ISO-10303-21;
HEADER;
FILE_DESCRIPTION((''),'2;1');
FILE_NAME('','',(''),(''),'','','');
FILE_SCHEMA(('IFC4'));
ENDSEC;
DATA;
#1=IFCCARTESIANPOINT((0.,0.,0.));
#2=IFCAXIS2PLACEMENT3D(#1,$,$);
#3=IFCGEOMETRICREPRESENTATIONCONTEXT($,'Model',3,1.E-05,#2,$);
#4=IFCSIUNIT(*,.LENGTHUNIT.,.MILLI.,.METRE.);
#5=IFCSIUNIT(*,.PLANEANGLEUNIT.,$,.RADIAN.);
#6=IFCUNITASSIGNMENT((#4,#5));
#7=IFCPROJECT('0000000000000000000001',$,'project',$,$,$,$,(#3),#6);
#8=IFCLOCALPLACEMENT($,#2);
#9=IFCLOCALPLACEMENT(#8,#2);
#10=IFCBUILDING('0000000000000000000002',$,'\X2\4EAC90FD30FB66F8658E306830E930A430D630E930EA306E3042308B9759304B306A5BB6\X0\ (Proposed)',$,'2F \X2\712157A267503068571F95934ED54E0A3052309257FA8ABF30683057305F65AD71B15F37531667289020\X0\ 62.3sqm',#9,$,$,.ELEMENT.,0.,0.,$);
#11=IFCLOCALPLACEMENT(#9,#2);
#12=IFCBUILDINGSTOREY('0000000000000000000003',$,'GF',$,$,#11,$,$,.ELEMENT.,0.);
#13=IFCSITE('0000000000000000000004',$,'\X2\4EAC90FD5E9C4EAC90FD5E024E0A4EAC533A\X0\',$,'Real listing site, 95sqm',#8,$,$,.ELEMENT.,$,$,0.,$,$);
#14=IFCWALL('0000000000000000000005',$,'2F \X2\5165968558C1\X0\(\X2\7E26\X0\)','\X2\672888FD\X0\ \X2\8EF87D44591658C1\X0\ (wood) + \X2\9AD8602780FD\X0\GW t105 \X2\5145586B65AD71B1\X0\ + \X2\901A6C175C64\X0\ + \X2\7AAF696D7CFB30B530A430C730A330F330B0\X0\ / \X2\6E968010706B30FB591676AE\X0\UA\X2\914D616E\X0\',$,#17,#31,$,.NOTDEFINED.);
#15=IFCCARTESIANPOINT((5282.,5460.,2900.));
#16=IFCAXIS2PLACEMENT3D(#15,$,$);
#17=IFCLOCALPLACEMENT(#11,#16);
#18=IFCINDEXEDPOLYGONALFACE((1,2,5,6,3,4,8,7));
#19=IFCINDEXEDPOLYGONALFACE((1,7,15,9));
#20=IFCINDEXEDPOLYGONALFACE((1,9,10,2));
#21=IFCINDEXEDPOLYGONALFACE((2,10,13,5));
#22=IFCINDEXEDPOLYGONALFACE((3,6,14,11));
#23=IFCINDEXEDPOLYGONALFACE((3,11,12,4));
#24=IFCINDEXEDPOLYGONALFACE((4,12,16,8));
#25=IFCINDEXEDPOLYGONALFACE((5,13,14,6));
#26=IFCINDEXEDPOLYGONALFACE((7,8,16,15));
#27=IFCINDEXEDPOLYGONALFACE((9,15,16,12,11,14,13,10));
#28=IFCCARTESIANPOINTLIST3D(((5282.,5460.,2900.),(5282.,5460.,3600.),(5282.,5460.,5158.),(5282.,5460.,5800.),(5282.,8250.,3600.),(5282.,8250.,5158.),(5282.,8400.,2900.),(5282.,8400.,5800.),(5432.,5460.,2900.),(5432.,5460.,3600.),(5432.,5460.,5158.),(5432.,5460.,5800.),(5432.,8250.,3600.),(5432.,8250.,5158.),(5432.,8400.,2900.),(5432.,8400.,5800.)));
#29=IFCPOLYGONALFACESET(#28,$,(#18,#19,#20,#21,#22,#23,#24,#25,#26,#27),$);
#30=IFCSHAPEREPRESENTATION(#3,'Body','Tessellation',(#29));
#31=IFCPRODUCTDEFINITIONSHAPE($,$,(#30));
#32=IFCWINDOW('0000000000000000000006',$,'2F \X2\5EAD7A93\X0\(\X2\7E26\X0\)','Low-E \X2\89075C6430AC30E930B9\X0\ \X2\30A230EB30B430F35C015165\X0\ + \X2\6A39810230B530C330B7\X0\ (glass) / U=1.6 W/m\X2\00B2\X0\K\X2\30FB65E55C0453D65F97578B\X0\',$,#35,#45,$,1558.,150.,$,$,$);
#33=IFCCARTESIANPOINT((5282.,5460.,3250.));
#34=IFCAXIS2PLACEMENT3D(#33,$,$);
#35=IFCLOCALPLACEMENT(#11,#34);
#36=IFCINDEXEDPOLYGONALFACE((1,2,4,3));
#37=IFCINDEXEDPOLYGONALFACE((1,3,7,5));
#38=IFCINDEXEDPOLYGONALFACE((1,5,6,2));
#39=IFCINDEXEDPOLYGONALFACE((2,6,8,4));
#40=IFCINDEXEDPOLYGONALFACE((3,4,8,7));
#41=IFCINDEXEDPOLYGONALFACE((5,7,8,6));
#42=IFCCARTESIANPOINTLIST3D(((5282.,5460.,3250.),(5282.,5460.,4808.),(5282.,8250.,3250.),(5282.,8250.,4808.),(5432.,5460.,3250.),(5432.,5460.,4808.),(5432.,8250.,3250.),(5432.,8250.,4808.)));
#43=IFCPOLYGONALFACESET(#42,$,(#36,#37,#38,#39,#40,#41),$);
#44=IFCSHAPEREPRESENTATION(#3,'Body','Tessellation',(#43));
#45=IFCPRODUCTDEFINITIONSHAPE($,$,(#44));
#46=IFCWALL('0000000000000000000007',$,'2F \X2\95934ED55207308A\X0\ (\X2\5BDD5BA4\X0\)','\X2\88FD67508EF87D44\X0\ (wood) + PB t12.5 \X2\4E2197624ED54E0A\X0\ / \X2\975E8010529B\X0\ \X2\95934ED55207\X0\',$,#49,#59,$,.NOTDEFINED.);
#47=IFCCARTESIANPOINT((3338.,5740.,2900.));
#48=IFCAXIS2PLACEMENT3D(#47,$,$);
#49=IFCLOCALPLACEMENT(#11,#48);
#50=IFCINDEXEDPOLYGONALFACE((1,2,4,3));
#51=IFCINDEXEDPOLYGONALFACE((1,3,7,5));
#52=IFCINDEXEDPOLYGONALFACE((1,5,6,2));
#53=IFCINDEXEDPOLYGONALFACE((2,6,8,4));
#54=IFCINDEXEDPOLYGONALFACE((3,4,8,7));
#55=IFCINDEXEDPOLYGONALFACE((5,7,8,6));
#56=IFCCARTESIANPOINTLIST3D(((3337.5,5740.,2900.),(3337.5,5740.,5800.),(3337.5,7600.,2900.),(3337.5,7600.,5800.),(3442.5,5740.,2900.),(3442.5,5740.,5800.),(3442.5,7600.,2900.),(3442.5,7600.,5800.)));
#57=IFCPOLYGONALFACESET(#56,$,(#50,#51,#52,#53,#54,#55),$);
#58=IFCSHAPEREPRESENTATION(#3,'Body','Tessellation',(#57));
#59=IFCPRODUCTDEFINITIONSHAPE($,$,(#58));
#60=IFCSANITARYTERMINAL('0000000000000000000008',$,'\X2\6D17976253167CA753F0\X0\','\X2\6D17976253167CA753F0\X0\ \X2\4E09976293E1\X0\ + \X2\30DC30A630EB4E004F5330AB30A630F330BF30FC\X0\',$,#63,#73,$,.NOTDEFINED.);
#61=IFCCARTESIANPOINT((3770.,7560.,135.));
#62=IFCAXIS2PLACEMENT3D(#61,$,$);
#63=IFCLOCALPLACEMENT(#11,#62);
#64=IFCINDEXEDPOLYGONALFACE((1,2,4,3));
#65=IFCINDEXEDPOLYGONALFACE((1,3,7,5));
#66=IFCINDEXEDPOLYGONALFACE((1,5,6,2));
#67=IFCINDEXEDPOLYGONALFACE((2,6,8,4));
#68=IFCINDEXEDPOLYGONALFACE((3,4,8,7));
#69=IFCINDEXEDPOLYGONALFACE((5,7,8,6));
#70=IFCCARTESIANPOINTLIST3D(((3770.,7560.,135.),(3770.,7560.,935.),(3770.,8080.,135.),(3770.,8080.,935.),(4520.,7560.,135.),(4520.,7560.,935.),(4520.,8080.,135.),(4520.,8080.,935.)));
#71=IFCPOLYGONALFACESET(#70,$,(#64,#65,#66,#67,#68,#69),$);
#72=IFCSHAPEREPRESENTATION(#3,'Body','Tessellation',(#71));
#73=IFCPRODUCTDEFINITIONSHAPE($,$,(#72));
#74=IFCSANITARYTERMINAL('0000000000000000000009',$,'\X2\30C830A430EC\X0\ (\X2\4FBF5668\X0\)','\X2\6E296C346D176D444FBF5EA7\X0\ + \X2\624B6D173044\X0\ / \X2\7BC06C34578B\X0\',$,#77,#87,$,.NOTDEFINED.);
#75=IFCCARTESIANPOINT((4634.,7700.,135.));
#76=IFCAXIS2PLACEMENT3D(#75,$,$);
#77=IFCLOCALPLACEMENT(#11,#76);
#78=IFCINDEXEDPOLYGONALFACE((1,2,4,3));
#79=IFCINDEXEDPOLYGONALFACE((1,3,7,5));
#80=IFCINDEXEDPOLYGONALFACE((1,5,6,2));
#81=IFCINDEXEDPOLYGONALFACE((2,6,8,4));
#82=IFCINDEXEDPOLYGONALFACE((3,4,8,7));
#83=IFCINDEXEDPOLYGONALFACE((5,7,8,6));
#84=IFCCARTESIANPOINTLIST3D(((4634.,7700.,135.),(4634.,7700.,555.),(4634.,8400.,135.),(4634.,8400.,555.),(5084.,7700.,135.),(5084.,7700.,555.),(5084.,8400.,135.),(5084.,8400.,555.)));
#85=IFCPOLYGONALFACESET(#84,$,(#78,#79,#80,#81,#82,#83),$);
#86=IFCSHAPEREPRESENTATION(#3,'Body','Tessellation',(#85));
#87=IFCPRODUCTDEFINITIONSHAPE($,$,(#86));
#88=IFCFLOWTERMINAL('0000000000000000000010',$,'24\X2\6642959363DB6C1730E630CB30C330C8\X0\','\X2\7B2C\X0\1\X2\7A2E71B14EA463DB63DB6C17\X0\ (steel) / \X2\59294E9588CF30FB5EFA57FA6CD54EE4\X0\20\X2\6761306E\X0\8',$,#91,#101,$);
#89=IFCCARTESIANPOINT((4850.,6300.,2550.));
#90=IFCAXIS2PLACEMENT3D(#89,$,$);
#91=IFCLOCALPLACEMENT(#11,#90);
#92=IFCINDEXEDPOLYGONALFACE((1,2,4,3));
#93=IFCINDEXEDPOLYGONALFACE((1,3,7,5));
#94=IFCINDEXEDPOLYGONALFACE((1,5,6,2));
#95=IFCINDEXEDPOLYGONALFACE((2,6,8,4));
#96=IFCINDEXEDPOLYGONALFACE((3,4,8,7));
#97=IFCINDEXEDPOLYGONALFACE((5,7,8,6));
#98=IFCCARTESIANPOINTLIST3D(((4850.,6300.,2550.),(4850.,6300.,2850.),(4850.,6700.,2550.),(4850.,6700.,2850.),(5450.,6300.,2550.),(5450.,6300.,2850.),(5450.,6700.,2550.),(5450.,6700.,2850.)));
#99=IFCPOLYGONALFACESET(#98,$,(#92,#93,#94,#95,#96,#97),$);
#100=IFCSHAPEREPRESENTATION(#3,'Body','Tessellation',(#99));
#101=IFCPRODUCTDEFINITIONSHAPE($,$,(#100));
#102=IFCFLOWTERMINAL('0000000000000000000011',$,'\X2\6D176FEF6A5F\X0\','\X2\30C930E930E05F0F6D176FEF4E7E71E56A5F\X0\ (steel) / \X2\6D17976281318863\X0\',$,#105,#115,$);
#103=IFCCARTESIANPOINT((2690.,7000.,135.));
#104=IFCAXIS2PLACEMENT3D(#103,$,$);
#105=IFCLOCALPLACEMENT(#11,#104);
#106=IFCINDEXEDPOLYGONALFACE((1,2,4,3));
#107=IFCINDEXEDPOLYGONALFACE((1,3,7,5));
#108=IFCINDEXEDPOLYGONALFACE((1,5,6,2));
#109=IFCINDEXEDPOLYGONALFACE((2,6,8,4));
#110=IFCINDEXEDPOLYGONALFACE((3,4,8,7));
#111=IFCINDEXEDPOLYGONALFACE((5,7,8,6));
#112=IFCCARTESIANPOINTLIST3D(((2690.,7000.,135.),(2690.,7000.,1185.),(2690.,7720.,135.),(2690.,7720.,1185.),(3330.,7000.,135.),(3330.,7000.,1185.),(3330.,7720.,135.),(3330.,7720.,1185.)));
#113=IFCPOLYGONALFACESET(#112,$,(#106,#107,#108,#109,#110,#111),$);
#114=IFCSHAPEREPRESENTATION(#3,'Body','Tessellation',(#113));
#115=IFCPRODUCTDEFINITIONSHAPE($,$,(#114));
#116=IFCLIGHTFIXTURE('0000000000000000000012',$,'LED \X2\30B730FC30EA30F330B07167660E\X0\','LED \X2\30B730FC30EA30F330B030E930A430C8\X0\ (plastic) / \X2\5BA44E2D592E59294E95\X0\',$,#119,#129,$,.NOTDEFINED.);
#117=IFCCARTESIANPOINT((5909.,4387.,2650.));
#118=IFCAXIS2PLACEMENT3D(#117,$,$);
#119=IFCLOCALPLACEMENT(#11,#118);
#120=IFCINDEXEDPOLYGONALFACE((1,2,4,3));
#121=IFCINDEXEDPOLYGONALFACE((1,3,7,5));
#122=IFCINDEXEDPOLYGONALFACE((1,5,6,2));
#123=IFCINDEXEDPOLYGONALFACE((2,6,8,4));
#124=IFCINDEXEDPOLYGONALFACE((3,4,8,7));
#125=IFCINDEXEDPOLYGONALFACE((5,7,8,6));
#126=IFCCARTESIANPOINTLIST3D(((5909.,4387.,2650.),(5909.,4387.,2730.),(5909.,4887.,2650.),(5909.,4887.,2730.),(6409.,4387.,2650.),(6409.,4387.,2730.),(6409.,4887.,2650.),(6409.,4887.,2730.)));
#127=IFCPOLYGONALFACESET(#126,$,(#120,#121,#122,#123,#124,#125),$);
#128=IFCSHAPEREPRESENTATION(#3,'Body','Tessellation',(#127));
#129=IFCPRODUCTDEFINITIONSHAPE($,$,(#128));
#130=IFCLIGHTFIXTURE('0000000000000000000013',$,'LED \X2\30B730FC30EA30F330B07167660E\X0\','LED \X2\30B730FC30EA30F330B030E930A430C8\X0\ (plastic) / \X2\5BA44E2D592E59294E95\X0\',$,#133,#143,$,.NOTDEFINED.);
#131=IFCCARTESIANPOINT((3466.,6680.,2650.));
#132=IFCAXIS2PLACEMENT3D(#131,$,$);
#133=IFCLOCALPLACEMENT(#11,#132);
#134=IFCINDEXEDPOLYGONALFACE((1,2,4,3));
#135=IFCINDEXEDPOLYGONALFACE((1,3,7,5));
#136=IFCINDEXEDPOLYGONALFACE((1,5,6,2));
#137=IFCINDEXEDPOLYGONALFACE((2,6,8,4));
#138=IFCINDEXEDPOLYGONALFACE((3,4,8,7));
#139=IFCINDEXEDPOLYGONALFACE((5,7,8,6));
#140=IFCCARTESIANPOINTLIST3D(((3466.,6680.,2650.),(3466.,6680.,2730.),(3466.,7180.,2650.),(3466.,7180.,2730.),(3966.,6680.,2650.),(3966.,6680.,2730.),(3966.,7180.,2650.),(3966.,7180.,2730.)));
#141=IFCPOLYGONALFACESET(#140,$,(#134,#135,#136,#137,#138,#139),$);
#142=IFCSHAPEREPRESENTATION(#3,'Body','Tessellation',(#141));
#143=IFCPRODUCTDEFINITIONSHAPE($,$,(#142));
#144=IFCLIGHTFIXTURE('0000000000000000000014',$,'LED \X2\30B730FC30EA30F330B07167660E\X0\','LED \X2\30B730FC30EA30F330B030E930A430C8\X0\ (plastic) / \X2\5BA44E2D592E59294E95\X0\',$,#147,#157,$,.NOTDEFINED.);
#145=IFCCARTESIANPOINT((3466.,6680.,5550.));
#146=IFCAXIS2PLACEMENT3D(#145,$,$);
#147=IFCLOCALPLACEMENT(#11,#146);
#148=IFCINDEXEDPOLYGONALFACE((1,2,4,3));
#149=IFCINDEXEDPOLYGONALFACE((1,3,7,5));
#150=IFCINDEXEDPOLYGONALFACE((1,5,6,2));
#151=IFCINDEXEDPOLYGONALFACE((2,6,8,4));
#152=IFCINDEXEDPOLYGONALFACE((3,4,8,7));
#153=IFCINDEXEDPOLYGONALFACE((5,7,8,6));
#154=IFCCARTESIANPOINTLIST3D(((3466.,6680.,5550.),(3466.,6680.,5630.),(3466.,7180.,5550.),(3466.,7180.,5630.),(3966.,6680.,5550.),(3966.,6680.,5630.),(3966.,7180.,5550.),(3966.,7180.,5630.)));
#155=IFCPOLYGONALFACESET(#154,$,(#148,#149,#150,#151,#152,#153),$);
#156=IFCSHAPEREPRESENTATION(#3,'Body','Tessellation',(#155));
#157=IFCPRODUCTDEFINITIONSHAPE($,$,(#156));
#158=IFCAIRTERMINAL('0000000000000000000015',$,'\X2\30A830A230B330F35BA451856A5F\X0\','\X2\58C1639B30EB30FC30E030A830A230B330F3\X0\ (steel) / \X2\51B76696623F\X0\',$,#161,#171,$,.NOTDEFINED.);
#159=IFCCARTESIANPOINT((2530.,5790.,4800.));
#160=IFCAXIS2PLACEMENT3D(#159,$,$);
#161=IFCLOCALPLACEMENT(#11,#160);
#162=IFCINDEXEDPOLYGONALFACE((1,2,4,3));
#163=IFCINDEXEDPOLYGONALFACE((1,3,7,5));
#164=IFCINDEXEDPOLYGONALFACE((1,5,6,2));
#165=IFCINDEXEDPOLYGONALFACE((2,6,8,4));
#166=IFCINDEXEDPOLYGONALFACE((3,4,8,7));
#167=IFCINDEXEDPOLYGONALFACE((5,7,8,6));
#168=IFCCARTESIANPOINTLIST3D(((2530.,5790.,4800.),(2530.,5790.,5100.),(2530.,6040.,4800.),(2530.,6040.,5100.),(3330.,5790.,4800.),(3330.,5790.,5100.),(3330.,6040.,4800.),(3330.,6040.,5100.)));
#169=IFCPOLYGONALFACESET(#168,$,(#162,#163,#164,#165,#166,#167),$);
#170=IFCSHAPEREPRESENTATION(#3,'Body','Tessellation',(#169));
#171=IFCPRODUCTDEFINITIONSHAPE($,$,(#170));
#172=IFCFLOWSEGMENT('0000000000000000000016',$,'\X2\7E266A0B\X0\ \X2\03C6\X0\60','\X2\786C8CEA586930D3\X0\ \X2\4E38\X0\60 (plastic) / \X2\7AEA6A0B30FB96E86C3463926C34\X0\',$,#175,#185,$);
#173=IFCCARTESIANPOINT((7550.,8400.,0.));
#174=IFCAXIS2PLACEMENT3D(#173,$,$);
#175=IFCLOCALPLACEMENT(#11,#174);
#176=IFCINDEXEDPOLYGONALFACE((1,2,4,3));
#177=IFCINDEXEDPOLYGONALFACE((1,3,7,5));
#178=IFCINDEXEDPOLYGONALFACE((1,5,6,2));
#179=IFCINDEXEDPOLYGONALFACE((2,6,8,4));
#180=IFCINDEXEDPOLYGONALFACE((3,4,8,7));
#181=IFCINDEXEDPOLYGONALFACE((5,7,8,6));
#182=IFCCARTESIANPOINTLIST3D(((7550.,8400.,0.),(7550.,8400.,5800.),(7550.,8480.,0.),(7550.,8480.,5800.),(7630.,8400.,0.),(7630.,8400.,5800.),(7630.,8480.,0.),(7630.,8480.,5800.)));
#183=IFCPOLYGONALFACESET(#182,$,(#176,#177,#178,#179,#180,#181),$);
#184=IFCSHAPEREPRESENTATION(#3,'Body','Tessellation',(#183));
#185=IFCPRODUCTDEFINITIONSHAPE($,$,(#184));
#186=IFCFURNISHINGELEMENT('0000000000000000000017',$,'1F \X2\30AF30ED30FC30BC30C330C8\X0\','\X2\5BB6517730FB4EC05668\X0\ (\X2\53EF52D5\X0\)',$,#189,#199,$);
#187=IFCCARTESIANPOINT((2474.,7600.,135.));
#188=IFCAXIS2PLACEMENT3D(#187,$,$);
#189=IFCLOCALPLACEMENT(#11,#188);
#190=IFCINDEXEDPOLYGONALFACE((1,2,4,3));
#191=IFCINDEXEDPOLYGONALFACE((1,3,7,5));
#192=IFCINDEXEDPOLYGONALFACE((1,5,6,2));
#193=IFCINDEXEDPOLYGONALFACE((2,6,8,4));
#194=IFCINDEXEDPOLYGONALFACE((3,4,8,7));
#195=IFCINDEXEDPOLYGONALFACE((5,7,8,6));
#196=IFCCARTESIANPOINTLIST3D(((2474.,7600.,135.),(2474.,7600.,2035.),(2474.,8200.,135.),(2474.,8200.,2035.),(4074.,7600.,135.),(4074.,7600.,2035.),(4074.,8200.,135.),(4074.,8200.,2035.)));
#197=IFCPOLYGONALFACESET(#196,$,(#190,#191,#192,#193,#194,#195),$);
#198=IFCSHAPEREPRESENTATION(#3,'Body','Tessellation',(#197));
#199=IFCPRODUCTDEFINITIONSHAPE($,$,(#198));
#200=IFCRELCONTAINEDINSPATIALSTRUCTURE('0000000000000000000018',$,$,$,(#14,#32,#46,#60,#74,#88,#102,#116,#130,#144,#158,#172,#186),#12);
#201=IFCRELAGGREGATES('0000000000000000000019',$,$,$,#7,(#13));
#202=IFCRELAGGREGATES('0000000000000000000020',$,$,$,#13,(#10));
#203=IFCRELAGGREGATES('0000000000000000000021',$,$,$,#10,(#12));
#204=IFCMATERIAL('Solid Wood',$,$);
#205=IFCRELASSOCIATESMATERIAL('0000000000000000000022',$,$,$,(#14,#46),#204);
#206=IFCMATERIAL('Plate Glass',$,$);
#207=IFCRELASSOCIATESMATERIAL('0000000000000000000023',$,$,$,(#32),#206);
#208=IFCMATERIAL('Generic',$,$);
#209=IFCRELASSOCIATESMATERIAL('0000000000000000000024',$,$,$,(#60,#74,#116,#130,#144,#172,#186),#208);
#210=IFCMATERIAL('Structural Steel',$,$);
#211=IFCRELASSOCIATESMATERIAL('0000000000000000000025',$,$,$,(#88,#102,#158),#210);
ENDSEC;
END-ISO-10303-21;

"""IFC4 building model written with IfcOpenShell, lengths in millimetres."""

from ifc_helpers import new_model, si_unit, frame, frame_2d, origin, place, context, project, spatial, rectangle, extrude, material, element, fill, save


model = new_model("IFC4")

# Units and contexts
model_context = context("Model", 3, precision=1e-05, world=origin())
ifc_project = project(units=[si_unit("LENGTHUNIT", "METRE", prefix="MILLI"), si_unit("PLANEANGLEUNIT", "RADIAN")], contexts=[model_context])

# Site, building, storey
site_placement = place(None, origin())
site = spatial("IfcSite", under=ifc_project, at=site_placement, Name="京都府京都市上京区", ObjectType="Real listing site, 95sqm", CompositionType="ELEMENT", RefElevation=0.0)
building_placement = place(site_placement, origin())
building = spatial("IfcBuilding", under=site, at=building_placement, Name="京都・書斎とライブラリのある静かな家 (Proposed)", ObjectType="2F 無垢材と土間仕上げを基調とした断熱強化木造 62.3sqm", CompositionType="ELEMENT", ElevationOfRefHeight=0.0, ElevationOfTerrain=0.0)
storey_placement = place(building_placement, origin())
storey = spatial("IfcBuildingStorey", under=building, at=storey_placement, Name="GF", CompositionType="ELEMENT", Elevation=0.0)

# Shared definitions
ifc_material_1 = material(Name="Solid Wood")

# Shared definitions
ifc_material_2 = material(Name="Plate Glass")

# Wall, opening, window
wall_1_placement = place(storey_placement, frame((5282.0, 5460.0, 2900.0)))
wall_1 = element("IfcWall", 1, at=wall_1_placement, inside=storey, material=ifc_material_1, Name="2F 入隅壁(縦)", Description="木製 軸組外壁 (wood) + 高性能GW t105 充填断熱 + 通気層 + 窯業系サイディング / 準耐火・外皮UA配慮", PredefinedType="NOTDEFINED", context=model_context, shape_type="SweptSolid", body=[
    extrude(rectangle(XDim=150.0, YDim=2940.0, at=frame_2d((75.0, 1470.0))), frame((5282.0, 5460.0, 2900.0)), (0.0, 0.0, 1.0), 2900.0),
])
opening_1_placement = place(storey_placement, frame((5282.0, 5460.0, 3250.0)))
opening_1 = element("IfcOpeningElement", 2, at=opening_1_placement, cuts=wall_1, PredefinedType="NOTDEFINED", context=model_context, shape_type="SweptSolid", body=[
    extrude(rectangle(XDim=150.0, YDim=2790.0, at=frame_2d((75.0, 1395.0))), frame((5282.0, 5460.0, 3250.0)), (0.0, 0.0, 1.0), 1558.0),
])
window_1_placement = place(storey_placement, frame((5282.0, 5460.0, 3250.0)))
window_1 = element("IfcWindow", 3, at=window_1_placement, inside=storey, material=ifc_material_2, Name="2F 庭窓(縦)", Description="Low-E 複層ガラス アルゴン封入 + 樹脂サッシ (glass) / U=1.6 W/m²K・日射取得型", OverallHeight=1558.0, OverallWidth=150.0, context=model_context, shape_type="SweptSolid", body=[
    extrude(rectangle(XDim=150.0, YDim=2790.0, at=frame_2d((75.0, 1395.0))), frame((5282.0, 5460.0, 3250.0)), (0.0, 0.0, 1.0), 1558.0),
])
fill(opening_1, window_1)

# Wall
wall_2_placement = place(storey_placement, frame((3338.0, 5740.0, 2900.0)))
element("IfcWall", 4, at=wall_2_placement, inside=storey, material=ifc_material_1, Name="2F 間仕切り (寝室)", Description="製材軸組 (wood) + PB t12.5 両面仕上 / 非耐力 間仕切", PredefinedType="NOTDEFINED", context=model_context, shape_type="SweptSolid", body=[
    extrude(rectangle(XDim=105.0, YDim=1860.0, at=frame_2d((52.0, 930.0))), frame((3338.0, 5740.0, 2900.0)), (0.0, 0.0, 1.0), 2900.0),
])

# Sanitary terminals
ifc_material_3 = material(Name="Generic")
sanitary_terminal_1_placement = place(storey_placement, frame((3770.0, 7560.0, 135.0)))
element("IfcSanitaryTerminal", 5, at=sanitary_terminal_1_placement, inside=storey, material=ifc_material_3, Name="洗面化粧台", Description="洗面化粧台 三面鏡 + ボウル一体カウンター", PredefinedType="NOTDEFINED", context=model_context, shape_type="SweptSolid", body=[
    extrude(rectangle(XDim=750.0, YDim=520.0, at=frame_2d((375.0, 260.0))), frame((3770.0, 7560.0, 135.0)), (0.0, 0.0, 1.0), 800.0),
])
sanitary_terminal_2_placement = place(storey_placement, frame((4634.0, 7700.0, 135.0)))
element("IfcSanitaryTerminal", 6, at=sanitary_terminal_2_placement, inside=storey, material=ifc_material_3, Name="トイレ (便器)", Description="温水洗浄便座 + 手洗い / 節水型", PredefinedType="NOTDEFINED", context=model_context, shape_type="SweptSolid", body=[
    extrude(rectangle(XDim=450.0, YDim=700.0, at=frame_2d((225.0, 350.0))), frame((4634.0, 7700.0, 135.0)), (0.0, 0.0, 1.0), 420.0),
])

# Flow terminals
ifc_material_4 = material(Name="Structural Steel")
flow_terminal_1_placement = place(storey_placement, frame((4850.0, 6300.0, 2550.0)))
element("IfcFlowTerminal", 7, at=flow_terminal_1_placement, inside=storey, material=ifc_material_4, Name="24時間換気ユニット", Description="第1種熱交換換気 (steel) / 天井裏・建基法令20条の8", context=model_context, shape_type="SweptSolid", body=[
    extrude(rectangle(XDim=600.0, YDim=400.0, at=frame_2d((300.0, 200.0))), frame((4850.0, 6300.0, 2550.0)), (0.0, 0.0, 1.0), 300.0),
])
flow_terminal_2_placement = place(storey_placement, frame((2690.0, 7000.0, 135.0)))
element("IfcFlowTerminal", 8, at=flow_terminal_2_placement, inside=storey, material=ifc_material_4, Name="洗濯機", Description="ドラム式洗濯乾燥機 (steel) / 洗面脱衣", context=model_context, shape_type="SweptSolid", body=[
    extrude(rectangle(XDim=640.0, YDim=720.0, at=frame_2d((320.0, 360.0))), frame((2690.0, 7000.0, 135.0)), (0.0, 0.0, 1.0), 1050.0),
])

# Light fixtures
light_fixture_1_placement = place(storey_placement, frame((5909.0, 4387.0, 2650.0)))
element("IfcLightFixture", 9, at=light_fixture_1_placement, inside=storey, material=ifc_material_3, Name="LED シーリング照明", Description="LED シーリングライト (plastic) / 室中央天井", PredefinedType="NOTDEFINED", context=model_context, shape_type="SweptSolid", body=[
    extrude(rectangle(XDim=500.0, YDim=500.0, at=frame_2d((250.0, 250.0))), frame((5909.0, 4387.0, 2650.0)), (0.0, 0.0, 1.0), 80.0),
])
light_fixture_2_placement = place(storey_placement, frame((3466.0, 6680.0, 2650.0)))
element("IfcLightFixture", 10, at=light_fixture_2_placement, inside=storey, material=ifc_material_3, Name="LED シーリング照明", Description="LED シーリングライト (plastic) / 室中央天井", PredefinedType="NOTDEFINED", context=model_context, shape_type="SweptSolid", body=[
    extrude(rectangle(XDim=500.0, YDim=500.0, at=frame_2d((250.0, 250.0))), frame((3466.0, 6680.0, 2650.0)), (0.0, 0.0, 1.0), 80.0),
])
light_fixture_3_placement = place(storey_placement, frame((3466.0, 6680.0, 5550.0)))
element("IfcLightFixture", 11, at=light_fixture_3_placement, inside=storey, material=ifc_material_3, Name="LED シーリング照明", Description="LED シーリングライト (plastic) / 室中央天井", PredefinedType="NOTDEFINED", context=model_context, shape_type="SweptSolid", body=[
    extrude(rectangle(XDim=500.0, YDim=500.0, at=frame_2d((250.0, 250.0))), frame((3466.0, 6680.0, 5550.0)), (0.0, 0.0, 1.0), 80.0),
])

# Air terminal
air_terminal_placement = place(storey_placement, frame((2530.0, 5790.0, 4800.0)))
element("IfcAirTerminal", 12, at=air_terminal_placement, inside=storey, material=ifc_material_4, Name="エアコン室内機", Description="壁掛ルームエアコン (steel) / 冷暖房", PredefinedType="NOTDEFINED", context=model_context, shape_type="SweptSolid", body=[
    extrude(rectangle(XDim=800.0, YDim=250.0, at=frame_2d((400.0, 125.0))), frame((2530.0, 5790.0, 4800.0)), (0.0, 0.0, 1.0), 300.0),
])

# Flow segment
flow_segment_placement = place(storey_placement, frame((7550.0, 8400.0, 0.0)))
element("IfcFlowSegment", 13, at=flow_segment_placement, inside=storey, material=ifc_material_3, Name="縦樋 φ60", Description="硬質塩ビ 丸60 (plastic) / 竪樋・雨水排水", context=model_context, shape_type="SweptSolid", body=[
    extrude(rectangle(XDim=80.0, YDim=80.0, at=frame_2d((40.0, 40.0))), frame((7550.0, 8400.0, 0.0)), (0.0, 0.0, 1.0), 5800.0),
])

# Furnishing element
furnishing_1_placement = place(storey_placement, frame((2474.0, 7600.0, 135.0)))
element("IfcFurnishingElement", 14, at=furnishing_1_placement, inside=storey, material=ifc_material_3, Name="1F クローゼット", Description="家具・什器 (可動)", context=model_context, shape_type="SweptSolid", body=[
    extrude(rectangle(XDim=1600.0, YDim=600.0, at=frame_2d((800.0, 300.0))), frame((2474.0, 7600.0, 135.0)), (0.0, 0.0, 1.0), 1900.0),
])

save(model, "model.ifc")
